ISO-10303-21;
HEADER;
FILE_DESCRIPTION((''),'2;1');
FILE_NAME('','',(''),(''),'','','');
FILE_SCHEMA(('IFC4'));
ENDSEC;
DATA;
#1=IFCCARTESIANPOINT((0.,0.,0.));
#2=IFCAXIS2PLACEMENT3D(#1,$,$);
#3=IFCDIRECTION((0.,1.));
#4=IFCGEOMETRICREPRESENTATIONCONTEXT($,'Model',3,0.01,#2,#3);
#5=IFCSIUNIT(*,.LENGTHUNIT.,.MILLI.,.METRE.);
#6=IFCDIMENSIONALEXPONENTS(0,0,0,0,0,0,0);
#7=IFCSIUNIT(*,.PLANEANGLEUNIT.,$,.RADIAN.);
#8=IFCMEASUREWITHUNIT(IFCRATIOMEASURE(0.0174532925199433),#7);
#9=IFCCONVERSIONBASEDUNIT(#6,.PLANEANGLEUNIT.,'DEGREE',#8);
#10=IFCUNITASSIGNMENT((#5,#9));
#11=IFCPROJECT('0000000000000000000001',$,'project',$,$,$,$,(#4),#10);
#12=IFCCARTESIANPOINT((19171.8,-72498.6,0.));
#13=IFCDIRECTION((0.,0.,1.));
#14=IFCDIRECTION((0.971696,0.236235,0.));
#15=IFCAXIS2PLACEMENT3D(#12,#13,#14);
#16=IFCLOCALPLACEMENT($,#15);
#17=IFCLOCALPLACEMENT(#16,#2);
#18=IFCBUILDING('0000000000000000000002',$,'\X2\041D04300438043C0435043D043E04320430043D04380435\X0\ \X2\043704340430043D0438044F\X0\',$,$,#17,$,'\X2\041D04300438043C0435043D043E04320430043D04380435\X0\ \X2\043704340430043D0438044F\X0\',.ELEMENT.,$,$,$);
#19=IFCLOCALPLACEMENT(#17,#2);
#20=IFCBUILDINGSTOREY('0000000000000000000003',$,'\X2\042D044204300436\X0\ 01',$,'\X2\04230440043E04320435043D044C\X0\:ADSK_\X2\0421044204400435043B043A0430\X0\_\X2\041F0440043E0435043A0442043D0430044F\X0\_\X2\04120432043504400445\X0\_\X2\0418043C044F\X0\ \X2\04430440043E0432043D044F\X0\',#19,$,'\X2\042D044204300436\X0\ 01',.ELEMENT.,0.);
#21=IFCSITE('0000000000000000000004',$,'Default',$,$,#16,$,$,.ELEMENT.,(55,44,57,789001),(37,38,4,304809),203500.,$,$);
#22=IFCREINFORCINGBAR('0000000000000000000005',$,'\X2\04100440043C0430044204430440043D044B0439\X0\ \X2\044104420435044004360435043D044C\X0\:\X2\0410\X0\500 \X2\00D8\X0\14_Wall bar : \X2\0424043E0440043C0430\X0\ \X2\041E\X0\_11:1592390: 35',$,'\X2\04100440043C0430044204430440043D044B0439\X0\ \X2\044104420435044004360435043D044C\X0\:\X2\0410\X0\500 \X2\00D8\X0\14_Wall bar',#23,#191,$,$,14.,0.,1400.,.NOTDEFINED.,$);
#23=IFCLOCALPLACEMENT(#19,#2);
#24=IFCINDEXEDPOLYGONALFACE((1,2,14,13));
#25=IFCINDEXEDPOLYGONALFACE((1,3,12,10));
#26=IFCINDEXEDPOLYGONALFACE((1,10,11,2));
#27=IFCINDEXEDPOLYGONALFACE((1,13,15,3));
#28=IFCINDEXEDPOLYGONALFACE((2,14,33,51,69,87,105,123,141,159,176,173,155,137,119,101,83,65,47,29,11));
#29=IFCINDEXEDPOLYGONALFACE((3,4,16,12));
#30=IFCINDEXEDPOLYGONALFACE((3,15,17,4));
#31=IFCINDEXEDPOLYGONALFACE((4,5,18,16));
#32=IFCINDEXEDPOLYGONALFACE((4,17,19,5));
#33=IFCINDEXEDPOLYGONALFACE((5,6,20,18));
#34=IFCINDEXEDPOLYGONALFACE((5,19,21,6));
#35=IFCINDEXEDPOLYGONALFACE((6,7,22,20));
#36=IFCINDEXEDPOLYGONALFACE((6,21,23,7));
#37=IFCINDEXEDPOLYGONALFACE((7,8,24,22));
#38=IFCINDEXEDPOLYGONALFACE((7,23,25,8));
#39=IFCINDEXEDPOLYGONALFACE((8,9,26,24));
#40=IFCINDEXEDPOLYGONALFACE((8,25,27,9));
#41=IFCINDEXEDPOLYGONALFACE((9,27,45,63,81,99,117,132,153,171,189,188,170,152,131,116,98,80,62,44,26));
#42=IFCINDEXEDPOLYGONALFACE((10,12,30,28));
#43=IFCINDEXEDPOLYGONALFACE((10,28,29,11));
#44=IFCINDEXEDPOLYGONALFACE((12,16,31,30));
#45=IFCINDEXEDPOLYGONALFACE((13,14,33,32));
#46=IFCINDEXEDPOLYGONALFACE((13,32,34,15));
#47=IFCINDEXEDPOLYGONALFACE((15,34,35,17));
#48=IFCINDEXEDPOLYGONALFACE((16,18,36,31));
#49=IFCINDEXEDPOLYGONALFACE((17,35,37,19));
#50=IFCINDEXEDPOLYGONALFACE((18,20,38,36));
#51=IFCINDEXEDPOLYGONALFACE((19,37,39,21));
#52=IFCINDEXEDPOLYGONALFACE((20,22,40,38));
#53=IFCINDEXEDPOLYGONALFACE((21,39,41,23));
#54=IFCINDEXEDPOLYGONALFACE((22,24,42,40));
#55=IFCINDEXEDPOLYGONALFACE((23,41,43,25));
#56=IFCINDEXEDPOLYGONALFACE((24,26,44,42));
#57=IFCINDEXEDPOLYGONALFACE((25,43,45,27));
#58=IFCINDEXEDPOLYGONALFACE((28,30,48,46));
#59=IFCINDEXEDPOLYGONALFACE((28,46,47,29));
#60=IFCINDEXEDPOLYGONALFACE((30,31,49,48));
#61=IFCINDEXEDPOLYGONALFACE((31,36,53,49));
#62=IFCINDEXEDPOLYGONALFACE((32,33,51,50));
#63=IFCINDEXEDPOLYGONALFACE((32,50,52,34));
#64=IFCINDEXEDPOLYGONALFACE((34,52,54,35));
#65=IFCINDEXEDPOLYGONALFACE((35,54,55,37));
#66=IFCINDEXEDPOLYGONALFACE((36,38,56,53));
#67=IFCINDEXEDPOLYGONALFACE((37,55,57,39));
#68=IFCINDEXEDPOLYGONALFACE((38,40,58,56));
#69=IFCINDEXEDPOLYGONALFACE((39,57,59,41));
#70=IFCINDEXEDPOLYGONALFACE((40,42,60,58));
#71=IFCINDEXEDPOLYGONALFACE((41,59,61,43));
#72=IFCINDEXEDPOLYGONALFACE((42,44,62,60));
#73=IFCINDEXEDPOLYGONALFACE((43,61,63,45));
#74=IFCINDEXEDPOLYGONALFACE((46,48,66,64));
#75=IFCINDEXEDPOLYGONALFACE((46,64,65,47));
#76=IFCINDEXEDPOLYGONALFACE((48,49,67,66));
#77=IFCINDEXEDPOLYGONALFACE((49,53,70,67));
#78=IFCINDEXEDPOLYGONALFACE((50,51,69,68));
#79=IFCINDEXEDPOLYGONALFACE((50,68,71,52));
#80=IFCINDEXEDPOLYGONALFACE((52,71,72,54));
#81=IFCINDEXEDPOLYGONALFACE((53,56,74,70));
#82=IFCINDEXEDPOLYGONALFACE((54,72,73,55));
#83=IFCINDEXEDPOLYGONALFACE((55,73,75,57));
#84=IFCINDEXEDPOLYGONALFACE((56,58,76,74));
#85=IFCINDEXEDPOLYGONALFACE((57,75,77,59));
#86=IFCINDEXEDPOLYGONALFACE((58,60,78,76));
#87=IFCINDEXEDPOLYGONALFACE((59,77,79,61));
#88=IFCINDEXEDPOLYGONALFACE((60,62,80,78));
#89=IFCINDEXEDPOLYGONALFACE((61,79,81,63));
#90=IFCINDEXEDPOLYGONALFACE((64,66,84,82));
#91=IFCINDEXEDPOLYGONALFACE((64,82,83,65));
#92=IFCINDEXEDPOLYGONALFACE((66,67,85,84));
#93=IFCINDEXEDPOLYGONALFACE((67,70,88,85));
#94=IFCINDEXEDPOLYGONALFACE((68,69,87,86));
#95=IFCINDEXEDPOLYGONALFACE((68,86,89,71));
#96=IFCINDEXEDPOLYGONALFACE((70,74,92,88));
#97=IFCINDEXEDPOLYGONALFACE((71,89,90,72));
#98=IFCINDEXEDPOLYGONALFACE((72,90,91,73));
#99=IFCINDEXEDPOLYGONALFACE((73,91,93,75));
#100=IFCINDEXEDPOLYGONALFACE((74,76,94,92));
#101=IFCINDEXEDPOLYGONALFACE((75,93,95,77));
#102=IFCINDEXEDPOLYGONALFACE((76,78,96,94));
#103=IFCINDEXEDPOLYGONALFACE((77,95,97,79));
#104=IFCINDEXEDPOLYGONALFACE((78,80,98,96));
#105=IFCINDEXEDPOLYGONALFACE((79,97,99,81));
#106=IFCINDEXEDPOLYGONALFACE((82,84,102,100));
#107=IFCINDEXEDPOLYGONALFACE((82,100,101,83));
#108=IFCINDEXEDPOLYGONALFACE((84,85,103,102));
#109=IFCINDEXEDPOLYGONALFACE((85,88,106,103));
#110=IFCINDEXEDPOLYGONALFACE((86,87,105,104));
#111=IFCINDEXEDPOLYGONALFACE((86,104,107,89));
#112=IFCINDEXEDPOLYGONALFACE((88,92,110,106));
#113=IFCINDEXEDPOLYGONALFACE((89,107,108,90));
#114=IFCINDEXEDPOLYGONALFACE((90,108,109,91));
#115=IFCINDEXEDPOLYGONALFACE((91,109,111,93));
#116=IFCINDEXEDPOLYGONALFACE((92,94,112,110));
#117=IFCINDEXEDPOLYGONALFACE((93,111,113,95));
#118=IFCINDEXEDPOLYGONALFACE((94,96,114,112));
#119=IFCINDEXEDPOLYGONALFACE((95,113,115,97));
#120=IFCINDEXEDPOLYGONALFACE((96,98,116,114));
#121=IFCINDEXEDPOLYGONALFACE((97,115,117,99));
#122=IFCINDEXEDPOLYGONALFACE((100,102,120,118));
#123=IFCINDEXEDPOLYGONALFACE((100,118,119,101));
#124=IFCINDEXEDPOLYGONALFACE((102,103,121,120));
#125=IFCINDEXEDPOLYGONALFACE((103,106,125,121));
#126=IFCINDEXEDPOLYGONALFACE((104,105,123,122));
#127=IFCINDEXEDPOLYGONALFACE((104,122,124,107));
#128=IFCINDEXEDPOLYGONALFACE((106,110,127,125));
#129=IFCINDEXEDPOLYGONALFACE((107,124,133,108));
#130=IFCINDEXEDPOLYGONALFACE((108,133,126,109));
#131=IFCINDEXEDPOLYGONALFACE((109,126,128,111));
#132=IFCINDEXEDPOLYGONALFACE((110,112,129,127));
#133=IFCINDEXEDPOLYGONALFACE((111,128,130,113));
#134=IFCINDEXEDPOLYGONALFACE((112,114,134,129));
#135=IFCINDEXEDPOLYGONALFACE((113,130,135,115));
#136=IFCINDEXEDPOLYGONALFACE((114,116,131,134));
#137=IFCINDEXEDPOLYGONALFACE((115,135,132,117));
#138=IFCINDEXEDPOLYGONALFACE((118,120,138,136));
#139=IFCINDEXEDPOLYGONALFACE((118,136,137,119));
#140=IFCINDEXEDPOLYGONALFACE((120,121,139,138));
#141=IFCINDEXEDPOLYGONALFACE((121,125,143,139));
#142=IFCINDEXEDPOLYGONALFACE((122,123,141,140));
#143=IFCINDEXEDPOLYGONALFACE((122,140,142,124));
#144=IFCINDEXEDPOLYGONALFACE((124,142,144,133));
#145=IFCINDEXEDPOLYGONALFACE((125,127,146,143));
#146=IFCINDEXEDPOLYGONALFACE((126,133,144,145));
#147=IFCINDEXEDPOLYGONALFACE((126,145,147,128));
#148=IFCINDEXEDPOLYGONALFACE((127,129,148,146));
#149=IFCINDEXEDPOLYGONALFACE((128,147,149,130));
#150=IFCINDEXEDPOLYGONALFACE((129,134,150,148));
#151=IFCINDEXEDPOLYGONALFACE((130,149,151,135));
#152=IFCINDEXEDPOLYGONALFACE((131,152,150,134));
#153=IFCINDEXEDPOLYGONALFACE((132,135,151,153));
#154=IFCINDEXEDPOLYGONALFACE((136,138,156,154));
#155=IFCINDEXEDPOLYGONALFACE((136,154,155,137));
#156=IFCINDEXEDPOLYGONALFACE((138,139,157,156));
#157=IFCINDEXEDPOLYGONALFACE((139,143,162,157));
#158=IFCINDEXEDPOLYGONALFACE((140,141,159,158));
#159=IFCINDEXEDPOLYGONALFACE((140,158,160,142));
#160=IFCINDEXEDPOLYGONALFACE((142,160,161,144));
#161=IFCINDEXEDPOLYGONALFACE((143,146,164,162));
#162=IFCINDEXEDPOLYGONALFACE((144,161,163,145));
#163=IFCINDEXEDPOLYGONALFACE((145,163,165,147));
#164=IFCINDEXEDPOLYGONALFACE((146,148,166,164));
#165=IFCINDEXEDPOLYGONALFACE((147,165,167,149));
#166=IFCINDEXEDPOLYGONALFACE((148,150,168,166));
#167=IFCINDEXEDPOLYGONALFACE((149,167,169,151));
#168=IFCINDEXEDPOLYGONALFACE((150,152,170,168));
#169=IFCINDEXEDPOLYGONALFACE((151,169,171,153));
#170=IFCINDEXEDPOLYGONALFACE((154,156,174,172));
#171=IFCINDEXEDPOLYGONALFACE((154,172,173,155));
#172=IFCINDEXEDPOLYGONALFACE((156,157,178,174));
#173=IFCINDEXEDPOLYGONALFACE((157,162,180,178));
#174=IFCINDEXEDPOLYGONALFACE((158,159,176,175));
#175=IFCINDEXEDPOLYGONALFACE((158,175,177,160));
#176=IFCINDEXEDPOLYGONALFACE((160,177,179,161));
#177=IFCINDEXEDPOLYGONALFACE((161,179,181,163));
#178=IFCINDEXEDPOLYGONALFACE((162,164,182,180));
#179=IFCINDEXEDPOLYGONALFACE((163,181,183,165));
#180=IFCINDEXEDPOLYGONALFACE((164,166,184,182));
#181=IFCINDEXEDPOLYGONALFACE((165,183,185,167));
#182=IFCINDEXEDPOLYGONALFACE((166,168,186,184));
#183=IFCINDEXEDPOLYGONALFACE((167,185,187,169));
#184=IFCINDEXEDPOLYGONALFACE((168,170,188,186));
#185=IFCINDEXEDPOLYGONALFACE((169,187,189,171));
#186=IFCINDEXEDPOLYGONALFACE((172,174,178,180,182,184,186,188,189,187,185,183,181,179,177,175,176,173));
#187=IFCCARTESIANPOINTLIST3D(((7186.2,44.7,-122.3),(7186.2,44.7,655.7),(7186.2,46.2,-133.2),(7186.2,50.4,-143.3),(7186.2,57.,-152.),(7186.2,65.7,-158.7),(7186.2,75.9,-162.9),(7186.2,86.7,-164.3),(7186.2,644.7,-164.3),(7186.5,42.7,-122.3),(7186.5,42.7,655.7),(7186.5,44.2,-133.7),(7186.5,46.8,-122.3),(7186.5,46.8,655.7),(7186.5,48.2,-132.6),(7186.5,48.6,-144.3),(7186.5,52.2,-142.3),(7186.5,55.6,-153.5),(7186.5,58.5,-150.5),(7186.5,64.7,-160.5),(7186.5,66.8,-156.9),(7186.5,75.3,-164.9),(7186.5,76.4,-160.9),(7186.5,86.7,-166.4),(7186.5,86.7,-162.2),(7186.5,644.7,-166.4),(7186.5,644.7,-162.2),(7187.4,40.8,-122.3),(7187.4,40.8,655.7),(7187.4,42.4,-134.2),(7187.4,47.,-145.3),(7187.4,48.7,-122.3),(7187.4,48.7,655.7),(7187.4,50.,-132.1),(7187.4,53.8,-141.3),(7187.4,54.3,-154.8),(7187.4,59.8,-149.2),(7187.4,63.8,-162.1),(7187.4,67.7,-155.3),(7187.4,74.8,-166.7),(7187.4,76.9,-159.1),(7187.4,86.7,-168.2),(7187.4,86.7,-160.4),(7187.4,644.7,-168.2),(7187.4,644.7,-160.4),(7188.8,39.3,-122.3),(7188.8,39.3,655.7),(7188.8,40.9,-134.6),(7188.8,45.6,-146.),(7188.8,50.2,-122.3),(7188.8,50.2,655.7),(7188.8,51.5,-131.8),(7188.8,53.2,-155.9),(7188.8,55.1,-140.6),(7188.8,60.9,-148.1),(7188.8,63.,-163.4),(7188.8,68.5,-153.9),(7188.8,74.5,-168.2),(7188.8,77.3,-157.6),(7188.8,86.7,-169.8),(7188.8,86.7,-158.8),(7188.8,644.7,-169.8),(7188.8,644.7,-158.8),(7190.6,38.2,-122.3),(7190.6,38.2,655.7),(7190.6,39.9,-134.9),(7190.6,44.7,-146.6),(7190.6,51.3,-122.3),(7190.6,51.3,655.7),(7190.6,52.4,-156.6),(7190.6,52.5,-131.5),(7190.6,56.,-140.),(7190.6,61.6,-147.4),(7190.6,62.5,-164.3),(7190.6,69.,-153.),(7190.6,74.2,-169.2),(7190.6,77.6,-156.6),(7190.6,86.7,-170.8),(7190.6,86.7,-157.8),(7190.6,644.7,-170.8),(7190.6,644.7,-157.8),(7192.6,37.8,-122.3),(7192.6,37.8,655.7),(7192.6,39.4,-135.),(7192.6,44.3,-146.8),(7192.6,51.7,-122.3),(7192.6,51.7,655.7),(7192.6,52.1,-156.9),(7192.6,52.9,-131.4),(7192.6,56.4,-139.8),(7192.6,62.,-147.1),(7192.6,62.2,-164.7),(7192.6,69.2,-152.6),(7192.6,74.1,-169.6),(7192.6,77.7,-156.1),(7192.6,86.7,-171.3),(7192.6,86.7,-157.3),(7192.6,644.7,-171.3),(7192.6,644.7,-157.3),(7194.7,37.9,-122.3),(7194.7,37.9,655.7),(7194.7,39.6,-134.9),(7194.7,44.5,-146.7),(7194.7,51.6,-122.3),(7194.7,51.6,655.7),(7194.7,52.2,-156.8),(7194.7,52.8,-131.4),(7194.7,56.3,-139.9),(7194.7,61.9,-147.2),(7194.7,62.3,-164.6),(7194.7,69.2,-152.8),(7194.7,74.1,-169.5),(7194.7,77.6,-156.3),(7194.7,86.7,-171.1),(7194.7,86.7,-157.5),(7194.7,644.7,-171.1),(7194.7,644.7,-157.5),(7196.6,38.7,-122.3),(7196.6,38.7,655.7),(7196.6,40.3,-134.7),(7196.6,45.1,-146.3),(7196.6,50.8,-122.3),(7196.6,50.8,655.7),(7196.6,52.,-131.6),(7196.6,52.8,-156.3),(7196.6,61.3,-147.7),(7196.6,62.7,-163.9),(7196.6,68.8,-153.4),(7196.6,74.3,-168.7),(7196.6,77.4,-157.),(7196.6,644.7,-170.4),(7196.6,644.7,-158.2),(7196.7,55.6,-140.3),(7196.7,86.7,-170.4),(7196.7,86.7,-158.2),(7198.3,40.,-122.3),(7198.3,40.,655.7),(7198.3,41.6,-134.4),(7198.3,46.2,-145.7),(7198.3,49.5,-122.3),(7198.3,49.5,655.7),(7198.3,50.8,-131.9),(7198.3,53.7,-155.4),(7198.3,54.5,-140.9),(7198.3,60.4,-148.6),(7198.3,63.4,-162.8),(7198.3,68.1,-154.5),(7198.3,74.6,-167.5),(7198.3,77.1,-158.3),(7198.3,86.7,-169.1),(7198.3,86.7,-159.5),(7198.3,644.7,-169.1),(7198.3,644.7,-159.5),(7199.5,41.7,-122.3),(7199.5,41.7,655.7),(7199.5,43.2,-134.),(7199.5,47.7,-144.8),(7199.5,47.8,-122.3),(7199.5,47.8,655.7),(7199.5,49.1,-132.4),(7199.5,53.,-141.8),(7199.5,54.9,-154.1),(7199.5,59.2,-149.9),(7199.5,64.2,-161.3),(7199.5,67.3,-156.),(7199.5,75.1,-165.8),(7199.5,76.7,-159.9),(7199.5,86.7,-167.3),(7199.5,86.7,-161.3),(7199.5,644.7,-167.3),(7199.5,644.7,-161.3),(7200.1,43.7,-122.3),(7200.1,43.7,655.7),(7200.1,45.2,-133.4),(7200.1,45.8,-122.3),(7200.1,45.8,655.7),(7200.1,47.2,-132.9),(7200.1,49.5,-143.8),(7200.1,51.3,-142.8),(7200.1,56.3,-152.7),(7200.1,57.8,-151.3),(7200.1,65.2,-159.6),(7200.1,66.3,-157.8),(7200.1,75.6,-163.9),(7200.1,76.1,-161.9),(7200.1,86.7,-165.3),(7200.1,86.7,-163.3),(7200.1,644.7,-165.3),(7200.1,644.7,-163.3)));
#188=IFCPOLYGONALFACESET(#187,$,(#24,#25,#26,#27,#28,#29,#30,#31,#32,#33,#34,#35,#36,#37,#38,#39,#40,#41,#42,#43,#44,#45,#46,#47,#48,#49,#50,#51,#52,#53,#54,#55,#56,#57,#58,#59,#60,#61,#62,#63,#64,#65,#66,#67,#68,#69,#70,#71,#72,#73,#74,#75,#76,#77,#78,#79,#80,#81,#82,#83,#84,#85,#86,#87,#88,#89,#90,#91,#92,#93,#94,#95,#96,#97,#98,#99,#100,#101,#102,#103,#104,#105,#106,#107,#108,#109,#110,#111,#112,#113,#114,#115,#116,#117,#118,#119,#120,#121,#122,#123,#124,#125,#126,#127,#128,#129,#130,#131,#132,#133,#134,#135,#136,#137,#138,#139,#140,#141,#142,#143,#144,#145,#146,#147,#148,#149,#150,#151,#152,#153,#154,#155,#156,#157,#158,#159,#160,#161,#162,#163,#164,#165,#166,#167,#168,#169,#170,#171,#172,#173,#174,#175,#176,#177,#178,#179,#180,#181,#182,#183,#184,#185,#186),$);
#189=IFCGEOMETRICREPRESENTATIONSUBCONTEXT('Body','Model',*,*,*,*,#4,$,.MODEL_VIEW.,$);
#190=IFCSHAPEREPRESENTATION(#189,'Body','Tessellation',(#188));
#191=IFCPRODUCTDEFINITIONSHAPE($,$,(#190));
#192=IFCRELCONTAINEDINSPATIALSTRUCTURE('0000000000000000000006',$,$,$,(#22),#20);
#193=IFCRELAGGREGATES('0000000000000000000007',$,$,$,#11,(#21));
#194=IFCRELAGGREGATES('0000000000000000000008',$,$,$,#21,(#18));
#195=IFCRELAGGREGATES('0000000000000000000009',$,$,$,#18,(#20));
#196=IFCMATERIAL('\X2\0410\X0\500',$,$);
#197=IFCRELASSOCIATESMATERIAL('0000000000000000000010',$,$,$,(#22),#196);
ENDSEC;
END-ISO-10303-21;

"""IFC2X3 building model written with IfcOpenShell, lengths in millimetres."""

from ifc_helpers import new_model, entity, si_unit, converted_unit, direction, frame, origin, place, context, subcontext, project, spatial, material, element, save


model = new_model("IFC2X3")

# Units and contexts
model_context = context("Model", 3, precision=0.01, world=origin(), true_north=direction((0.0, 1.0)))
body_context = subcontext(model_context, "Body", "Model", "MODEL_VIEW")
ifc_project = project(units=[si_unit("LENGTHUNIT", "METRE", prefix="MILLI"), converted_unit("PLANEANGLEUNIT", "DEGREE", entity("IfcRatioMeasure", 0.0174532925199433), si_unit("PLANEANGLEUNIT", "RADIAN"), dimensions=[0, 0, 0, 0, 0, 0, 0])], contexts=[model_context])

# Site, building, storey
site_placement = place(None, frame((19171.8, -72498.6, 0.0), z_axis=(0.0, 0.0, 1.0), x_axis=(0.971696, 0.236235, 0.0)))
site = spatial("IfcSite", under=ifc_project, at=site_placement, Name="Default", CompositionType="ELEMENT", RefLatitude=(55, 44, 57, 789001), RefLongitude=(37, 38, 4, 304809), RefElevation=203500.0)
building_placement = place(site_placement, origin())
building = spatial("IfcBuilding", under=site, at=building_placement, Name="Наименование здания", LongName="Наименование здания", CompositionType="ELEMENT")
storey_placement = place(building_placement, origin())
storey = spatial("IfcBuildingStorey", under=building, at=storey_placement, Name="Этаж 01", ObjectType="Уровень:ADSK_Стрелка_Проектная_Вверх_Имя уровня", LongName="Этаж 01", CompositionType="ELEMENT", Elevation=0.0)

# Reinforcing bar
ifc_material = material(Name="А500")
placement = place(storey_placement, origin())
element("IfcReinforcingBar", 1, at=placement, inside=storey, material=ifc_material, Name="Арматурный стержень:А500 Ø14_Wall bar : Форма О_11:1592390: 35", ObjectType="Арматурный стержень:А500 Ø14_Wall bar", BarLength=1400.0, BarRole="NOTDEFINED", CrossSectionArea=0.0, NominalDiameter=14.0, context=body_context, shape_type="AdvancedSweptSolid", body=[
    entity("IfcSweptDiskSolid", entity("IfcCompositeCurve", [entity("IfcCompositeCurveSegment", "CONTINUOUS", True, entity("IfcPolyline", [entity("IfcCartesianPoint", [7193.1, 44.7, 655.7]), entity("IfcCartesianPoint", [7193.1, 44.7, -122.3])])), entity("IfcCompositeCurveSegment", "CONTINUOUS", True, entity("IfcTrimmedCurve", entity("IfcCircle", entity("IfcAxis2Placement3D", entity("IfcCartesianPoint", [7193.1, 86.7, -122.3]), entity("IfcDirection", [1.0, 0.0, 0.0]), entity("IfcDirection", [0.0, 0.0, -1.0])), 42.0), [entity("IfcParameterValue", 270.0)], [entity("IfcParameterValue", 360.0)], True, "PARAMETER")), entity("IfcCompositeCurveSegment", "CONTINUOUS", True, entity("IfcPolyline", [entity("IfcCartesianPoint", [7193.1, 86.7, -164.3]), entity("IfcCartesianPoint", [7193.1, 644.7, -164.3])]))], False), 7.0, None, 0.0, 92.0),
])

save(model, "model.ifc")
